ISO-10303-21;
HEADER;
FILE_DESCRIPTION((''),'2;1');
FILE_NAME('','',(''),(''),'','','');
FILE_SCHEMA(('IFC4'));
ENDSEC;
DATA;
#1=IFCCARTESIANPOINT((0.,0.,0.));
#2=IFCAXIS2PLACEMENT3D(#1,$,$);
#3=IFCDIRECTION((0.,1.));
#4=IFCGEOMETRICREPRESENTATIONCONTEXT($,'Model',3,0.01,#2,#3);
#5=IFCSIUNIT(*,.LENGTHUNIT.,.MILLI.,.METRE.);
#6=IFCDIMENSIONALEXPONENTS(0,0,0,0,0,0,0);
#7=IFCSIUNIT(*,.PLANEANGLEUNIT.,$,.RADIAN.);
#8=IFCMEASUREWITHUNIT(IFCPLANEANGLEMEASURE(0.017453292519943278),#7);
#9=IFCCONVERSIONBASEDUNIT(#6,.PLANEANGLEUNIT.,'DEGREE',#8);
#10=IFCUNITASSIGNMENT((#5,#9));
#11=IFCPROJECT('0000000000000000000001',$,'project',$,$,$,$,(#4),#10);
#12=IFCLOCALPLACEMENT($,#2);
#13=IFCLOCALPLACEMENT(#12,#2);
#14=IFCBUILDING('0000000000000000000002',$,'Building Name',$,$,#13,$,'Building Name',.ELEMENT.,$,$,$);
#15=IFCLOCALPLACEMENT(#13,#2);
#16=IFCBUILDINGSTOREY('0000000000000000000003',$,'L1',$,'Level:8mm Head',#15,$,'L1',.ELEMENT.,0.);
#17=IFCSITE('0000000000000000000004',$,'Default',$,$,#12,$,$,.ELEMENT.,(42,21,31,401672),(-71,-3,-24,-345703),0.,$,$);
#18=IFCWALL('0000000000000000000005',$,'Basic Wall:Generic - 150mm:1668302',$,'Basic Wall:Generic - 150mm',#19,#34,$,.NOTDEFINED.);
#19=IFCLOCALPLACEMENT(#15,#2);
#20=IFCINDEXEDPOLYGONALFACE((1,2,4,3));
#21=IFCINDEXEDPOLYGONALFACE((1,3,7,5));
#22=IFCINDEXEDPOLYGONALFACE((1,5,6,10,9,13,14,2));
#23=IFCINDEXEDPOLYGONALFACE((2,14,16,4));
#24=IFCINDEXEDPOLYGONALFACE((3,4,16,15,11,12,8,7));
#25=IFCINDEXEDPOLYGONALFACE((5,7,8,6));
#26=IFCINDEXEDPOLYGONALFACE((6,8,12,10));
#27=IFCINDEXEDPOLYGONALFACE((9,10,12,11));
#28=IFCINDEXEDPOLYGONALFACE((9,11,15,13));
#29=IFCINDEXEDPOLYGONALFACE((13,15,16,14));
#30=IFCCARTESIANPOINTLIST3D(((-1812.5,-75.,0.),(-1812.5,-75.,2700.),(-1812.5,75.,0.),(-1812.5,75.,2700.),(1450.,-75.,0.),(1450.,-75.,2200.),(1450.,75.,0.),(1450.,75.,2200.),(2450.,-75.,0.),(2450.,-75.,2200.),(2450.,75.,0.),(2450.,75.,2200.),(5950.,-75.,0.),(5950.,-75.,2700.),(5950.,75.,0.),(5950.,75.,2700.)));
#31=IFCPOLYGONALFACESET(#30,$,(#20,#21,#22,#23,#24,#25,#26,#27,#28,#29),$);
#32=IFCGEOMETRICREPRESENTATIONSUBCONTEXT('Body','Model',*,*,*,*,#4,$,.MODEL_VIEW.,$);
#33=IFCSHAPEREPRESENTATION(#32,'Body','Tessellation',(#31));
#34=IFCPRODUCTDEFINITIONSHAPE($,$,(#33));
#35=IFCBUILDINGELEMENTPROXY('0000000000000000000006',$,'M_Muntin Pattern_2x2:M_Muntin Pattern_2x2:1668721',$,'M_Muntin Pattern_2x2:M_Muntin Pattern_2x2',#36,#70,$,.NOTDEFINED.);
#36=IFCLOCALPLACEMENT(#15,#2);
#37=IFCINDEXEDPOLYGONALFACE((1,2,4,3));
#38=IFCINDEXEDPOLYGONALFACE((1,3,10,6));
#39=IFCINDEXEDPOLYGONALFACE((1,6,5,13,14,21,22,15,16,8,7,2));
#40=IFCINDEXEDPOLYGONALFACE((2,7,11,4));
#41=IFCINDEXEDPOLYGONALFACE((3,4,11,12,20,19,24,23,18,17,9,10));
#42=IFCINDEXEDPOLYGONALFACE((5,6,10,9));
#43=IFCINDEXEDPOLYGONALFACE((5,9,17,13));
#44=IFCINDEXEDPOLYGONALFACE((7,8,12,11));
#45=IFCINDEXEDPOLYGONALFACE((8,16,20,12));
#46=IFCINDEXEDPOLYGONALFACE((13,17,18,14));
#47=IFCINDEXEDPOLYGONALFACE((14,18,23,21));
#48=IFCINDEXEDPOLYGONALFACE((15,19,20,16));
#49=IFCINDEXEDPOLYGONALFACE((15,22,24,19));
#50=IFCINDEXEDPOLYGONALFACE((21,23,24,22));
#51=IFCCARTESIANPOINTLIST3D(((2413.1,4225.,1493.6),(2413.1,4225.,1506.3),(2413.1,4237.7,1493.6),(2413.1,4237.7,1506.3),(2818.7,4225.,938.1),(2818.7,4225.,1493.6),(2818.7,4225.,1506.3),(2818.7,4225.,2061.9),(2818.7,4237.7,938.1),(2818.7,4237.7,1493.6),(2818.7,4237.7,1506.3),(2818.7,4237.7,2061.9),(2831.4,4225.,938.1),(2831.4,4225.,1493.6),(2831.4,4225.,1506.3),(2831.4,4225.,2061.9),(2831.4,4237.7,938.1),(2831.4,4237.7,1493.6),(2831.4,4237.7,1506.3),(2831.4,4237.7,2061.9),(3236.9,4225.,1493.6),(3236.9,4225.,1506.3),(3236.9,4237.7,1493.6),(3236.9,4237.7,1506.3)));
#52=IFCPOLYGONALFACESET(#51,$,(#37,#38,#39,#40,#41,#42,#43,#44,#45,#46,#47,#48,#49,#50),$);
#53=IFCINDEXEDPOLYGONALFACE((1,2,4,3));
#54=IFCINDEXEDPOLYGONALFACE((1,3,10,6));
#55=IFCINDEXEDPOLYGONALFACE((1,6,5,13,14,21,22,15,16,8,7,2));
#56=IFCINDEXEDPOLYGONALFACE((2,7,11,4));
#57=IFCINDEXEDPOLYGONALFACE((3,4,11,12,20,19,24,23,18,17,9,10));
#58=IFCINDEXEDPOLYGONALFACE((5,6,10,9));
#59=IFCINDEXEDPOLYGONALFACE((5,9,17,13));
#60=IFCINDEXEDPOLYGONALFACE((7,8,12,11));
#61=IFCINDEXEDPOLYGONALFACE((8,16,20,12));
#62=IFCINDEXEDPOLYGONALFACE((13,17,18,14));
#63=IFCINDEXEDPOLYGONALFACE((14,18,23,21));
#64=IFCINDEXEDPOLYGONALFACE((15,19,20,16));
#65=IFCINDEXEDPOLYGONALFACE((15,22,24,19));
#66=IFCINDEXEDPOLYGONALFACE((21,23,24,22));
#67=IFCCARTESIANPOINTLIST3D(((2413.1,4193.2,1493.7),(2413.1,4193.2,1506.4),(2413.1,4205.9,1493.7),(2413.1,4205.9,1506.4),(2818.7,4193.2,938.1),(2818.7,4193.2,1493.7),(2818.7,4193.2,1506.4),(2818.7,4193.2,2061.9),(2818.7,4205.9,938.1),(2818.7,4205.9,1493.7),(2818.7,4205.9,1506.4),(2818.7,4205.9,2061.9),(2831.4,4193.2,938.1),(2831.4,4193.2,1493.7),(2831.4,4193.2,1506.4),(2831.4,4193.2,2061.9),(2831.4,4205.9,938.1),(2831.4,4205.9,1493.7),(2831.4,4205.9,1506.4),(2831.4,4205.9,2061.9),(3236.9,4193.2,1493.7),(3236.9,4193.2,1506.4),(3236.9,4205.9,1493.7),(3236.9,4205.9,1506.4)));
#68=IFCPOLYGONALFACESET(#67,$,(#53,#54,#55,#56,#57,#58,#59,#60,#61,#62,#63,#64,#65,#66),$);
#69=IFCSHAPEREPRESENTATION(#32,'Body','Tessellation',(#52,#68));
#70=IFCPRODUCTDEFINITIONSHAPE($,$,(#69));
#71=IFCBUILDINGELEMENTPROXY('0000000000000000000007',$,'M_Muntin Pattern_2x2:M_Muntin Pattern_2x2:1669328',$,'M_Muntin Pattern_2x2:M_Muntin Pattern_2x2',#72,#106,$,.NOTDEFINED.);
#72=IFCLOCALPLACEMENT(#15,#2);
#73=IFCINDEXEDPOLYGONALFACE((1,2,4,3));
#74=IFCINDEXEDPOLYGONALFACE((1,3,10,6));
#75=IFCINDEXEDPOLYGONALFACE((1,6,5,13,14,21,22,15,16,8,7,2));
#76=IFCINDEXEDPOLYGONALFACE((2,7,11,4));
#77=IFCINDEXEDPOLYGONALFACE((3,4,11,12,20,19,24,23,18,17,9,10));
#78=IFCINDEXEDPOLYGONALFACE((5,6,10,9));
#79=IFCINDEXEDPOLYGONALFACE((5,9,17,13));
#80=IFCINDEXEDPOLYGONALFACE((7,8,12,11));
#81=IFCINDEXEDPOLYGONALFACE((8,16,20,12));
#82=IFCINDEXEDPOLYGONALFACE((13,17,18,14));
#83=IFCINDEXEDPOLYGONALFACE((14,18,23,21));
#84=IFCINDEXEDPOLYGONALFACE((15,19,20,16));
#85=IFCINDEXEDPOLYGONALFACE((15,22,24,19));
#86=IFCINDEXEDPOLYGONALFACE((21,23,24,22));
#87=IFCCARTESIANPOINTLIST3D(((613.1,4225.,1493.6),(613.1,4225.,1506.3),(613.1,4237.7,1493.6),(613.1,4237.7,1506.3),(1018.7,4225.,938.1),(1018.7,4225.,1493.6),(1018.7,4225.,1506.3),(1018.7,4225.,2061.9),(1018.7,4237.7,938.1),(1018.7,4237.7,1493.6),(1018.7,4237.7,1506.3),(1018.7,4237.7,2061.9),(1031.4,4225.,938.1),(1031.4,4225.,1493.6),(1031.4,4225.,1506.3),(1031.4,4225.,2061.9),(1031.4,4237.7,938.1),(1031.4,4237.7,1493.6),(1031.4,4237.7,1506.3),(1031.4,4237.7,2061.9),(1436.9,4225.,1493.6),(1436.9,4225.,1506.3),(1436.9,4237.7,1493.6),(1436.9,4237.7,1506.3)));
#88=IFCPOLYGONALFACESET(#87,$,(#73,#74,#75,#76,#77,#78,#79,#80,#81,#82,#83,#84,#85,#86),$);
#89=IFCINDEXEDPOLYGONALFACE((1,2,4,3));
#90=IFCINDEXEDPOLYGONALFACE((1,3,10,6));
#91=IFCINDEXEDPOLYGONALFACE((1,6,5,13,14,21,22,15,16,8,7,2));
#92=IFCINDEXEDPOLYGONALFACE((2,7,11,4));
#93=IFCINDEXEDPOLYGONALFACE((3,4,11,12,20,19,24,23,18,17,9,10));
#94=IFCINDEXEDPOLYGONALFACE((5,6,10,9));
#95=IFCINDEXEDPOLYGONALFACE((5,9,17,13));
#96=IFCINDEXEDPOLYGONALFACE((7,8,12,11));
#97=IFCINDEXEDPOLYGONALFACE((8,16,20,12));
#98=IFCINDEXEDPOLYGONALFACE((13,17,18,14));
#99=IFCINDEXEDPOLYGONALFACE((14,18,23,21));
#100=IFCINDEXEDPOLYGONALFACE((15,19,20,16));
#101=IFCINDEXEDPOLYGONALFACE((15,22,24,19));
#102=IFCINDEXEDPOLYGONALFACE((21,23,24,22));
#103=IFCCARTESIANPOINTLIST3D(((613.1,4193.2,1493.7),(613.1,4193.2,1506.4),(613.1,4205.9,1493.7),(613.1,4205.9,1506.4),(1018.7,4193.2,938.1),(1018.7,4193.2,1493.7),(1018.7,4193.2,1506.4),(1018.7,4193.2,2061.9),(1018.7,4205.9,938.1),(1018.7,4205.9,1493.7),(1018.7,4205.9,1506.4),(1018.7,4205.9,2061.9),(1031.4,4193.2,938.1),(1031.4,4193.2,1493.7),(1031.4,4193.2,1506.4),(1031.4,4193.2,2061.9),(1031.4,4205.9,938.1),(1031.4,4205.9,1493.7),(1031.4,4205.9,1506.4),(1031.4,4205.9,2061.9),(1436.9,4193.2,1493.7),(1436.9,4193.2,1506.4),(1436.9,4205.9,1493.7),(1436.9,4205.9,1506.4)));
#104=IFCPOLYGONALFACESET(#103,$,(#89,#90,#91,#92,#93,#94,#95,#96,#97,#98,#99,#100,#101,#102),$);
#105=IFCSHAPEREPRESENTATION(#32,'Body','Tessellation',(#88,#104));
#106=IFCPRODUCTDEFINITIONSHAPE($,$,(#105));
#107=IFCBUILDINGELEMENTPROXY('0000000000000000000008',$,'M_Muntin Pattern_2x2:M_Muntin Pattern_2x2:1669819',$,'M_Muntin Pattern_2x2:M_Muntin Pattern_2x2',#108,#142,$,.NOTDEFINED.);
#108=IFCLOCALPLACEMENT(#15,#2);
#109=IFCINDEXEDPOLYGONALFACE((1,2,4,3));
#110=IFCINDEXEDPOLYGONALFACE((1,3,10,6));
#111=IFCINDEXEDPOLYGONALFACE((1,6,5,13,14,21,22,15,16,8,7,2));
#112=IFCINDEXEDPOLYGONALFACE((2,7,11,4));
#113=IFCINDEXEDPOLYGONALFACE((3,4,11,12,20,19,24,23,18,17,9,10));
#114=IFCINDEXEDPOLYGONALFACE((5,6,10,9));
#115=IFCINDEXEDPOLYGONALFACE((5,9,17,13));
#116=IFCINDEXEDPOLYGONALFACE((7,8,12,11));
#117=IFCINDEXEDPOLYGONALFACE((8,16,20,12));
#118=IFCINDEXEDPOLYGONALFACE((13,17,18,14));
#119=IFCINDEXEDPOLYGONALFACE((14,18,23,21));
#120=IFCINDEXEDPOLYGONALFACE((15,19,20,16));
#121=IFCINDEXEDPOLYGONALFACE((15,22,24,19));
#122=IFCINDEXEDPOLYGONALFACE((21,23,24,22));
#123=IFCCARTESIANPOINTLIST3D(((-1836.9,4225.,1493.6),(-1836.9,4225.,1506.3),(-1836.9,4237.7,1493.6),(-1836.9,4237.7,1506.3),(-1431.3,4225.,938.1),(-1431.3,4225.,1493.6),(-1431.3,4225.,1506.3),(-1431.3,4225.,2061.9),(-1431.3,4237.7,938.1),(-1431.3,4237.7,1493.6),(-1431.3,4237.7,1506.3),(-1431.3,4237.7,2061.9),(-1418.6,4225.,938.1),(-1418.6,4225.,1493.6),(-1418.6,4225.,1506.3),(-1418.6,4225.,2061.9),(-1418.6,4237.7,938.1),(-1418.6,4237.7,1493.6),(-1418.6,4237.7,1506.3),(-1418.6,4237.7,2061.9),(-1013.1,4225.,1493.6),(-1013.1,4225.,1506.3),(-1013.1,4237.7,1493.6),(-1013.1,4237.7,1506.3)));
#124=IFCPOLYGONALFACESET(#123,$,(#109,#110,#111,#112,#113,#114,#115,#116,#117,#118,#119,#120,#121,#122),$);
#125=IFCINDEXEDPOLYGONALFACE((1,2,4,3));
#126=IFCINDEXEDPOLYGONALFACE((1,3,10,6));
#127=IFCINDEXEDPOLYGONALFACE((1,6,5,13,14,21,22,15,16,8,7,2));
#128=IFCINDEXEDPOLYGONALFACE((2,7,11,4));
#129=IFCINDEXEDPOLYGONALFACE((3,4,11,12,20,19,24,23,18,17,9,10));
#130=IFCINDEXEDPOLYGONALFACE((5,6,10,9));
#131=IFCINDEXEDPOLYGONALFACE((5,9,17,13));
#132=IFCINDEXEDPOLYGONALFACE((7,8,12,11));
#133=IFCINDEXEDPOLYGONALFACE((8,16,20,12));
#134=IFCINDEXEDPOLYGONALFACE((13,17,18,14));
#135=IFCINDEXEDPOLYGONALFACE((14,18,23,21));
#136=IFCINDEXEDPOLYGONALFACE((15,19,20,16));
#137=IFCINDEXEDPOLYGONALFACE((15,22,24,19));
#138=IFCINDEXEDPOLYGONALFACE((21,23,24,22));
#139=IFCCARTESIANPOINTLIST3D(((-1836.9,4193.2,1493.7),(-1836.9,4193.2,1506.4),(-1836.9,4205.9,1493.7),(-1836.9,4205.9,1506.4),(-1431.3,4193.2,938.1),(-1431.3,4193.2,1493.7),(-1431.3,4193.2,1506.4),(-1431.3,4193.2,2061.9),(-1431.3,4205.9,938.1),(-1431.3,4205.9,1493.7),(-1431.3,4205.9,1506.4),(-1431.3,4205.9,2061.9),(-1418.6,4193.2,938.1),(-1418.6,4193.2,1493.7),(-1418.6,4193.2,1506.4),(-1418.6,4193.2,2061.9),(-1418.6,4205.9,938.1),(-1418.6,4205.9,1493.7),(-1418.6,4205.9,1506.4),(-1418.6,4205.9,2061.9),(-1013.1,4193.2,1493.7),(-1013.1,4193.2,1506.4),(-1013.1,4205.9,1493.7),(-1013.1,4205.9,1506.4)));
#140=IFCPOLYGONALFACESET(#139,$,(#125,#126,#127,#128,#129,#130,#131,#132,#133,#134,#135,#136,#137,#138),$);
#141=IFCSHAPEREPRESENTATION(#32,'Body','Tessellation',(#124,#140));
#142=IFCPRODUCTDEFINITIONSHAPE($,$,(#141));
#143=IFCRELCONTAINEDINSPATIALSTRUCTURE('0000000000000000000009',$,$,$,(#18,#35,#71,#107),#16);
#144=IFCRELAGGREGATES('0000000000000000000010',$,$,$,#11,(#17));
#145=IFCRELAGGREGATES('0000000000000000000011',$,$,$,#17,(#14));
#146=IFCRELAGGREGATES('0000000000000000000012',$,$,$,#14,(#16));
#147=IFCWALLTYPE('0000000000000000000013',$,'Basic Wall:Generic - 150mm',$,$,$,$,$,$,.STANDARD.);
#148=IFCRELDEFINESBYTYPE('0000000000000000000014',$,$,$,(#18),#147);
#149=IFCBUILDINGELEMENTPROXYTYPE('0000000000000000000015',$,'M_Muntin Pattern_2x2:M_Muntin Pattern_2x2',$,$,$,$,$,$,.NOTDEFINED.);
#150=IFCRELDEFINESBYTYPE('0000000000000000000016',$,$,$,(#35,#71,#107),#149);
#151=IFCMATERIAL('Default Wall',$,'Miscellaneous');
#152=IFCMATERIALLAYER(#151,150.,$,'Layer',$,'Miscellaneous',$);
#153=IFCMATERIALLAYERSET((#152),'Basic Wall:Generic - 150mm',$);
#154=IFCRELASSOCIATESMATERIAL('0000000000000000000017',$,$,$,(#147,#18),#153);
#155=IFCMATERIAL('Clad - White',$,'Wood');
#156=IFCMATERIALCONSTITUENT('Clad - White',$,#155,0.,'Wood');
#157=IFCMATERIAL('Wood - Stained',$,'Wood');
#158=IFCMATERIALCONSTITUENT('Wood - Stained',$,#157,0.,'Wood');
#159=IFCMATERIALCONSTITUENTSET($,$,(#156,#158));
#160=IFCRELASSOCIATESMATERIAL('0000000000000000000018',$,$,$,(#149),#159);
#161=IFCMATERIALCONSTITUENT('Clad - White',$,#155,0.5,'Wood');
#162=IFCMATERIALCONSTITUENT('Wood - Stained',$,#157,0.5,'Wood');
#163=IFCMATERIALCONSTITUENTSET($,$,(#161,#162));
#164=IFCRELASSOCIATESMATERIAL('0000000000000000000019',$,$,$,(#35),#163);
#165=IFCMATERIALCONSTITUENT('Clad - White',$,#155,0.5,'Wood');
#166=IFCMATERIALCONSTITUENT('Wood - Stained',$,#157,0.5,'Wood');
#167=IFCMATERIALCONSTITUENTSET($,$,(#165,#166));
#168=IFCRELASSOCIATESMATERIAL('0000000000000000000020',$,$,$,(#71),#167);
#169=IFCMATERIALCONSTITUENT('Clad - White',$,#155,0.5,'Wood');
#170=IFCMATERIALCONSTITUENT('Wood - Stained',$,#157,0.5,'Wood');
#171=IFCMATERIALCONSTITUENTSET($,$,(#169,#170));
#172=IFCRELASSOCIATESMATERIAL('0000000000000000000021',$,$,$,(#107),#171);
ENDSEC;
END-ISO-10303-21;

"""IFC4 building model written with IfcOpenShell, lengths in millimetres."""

from ifc_helpers import new_model, entity, si_unit, converted_unit, direction, frame, frame_2d, origin, place, context, subcontext, project, spatial, polyline, rectangle, outline, extrude, source, transform, mapped, material, layer, layer_set, layer_usage, constituent, constituent_set, type_object, type_shapes, element, save


model = new_model("IFC4")

# Units and contexts
model_context = context("Model", 3, precision=0.01, world=origin(), true_north=direction((0.0, 1.0)))
body_context = subcontext(model_context, "Body", "Model", "MODEL_VIEW")
ifc_project = project(units=[si_unit("LENGTHUNIT", "METRE", prefix="MILLI"), converted_unit("PLANEANGLEUNIT", "DEGREE", entity("IfcPlaneAngleMeasure", 0.017453292519943278), si_unit("PLANEANGLEUNIT", "RADIAN"), dimensions=[0, 0, 0, 0, 0, 0, 0])], contexts=[model_context])

# Site, building, storey
site_placement = place(None, origin())
site = spatial("IfcSite", under=ifc_project, at=site_placement, Name="Default", CompositionType="ELEMENT", RefLatitude=(42, 21, 31, 401672), RefLongitude=(-71, -3, -24, -345703), RefElevation=0.0)
building_placement = place(site_placement, origin())
building = spatial("IfcBuilding", under=site, at=building_placement, Name="Building Name", LongName="Building Name", CompositionType="ELEMENT")
storey_placement = place(building_placement, origin())
storey = spatial("IfcBuildingStorey", under=building, at=storey_placement, Name="L1", ObjectType="Level:8mm Head", LongName="L1", CompositionType="ELEMENT", Elevation=0.0)

# Shared definitions
ifc_material_1 = material(Name="Default Wall", Category="Miscellaneous")
ifc_layer_1 = layer(ifc_material_1, 150.0, Name="Layer", Category="Miscellaneous")
ifc_layer_set_1 = layer_set([ifc_layer_1], Name="Basic Wall:Generic - 150mm")
wall_type = type_object("IfcWallType", Name="Basic Wall:Generic - 150mm", PredefinedType="STANDARD", material=ifc_layer_set_1)

# Wall, openings
ifc_layer_usage_1 = layer_usage(ifc_layer_set_1, "AXIS2", "NEGATIVE", 75.0)
wall_1_placement = place(storey_placement, frame((5950.0, 0.0, 0.0), z_axis=(0.0, 0.0, 1.0), x_axis=(-1.0, 0.0, 0.0)))
wall_1 = element("IfcWall", 1, at=wall_1_placement, inside=storey, type_object=wall_type, material=ifc_layer_usage_1, Name="Basic Wall:Generic - 150mm:1668302", ObjectType="Basic Wall:Generic - 150mm", PredefinedType="NOTDEFINED", context=body_context, shape_type="SweptSolid", body=[
    extrude(rectangle(XDim=7762.5, YDim=150.0, at=frame_2d((3881.2, 0.0), x_axis=(1.0, 0.0))), origin(), (0.0, 0.0, 1.0), 2700.0),
])
opening_1_placement = place(wall_1_placement, frame((3500.0, -75.0, 0.0)))
element("IfcOpeningElement", 2, at=opening_1_placement, cuts=wall_1, PredefinedType="OPENING", context=body_context, shape_type="SweptSolid", body=[
    extrude(rectangle(XDim=2200.0, YDim=1000.0, at=frame_2d((1100.0, 500.0), x_axis=(1.0, 0.0))), frame((0.0, 0.0, 0.0), z_axis=(0.0, 1.0, 0.0), x_axis=(0.0, 0.0, 1.0)), (0.0, 0.0, 1.0), 150.0),
])
opening_2_placement = place(wall_1_placement, frame((5950.0, 0.0, 0.0), z_axis=(0.0, 0.0, 1.0), x_axis=(-1.0, 0.0, 0.0)))
element("IfcOpeningElement", 3, at=opening_2_placement, cuts=wall_1, PredefinedType="OPENING", context=body_context, shape_type="SweptSolid", body=[
    extrude(rectangle(XDim=2200.0, YDim=1000.0, at=frame_2d((0.0, 0.0), x_axis=(1.0, 0.0))), frame((1950.0, 1599.0, 1100.0), z_axis=(0.0, -1.0, 0.0), x_axis=(0.0, 0.0, 1.0)), (0.0, 0.0, 1.0), 3048.0),
])

# Building element proxies
ifc_material_2 = material(Name="Clad - White", Category="Wood")
ifc_constituent_1 = constituent(ifc_material_2, Name="Clad - White", Category="Wood", fraction=0.5)
ifc_material_3 = material(Name="Wood - Stained", Category="Wood")
ifc_constituent_2 = constituent(ifc_material_3, Name="Wood - Stained", Category="Wood", fraction=0.5)
ifc_constituent_set_1 = constituent_set(constituents=[ifc_constituent_1, ifc_constituent_2])
ifc_constituent_3 = constituent(ifc_material_2, Name="Clad - White", Category="Wood", fraction=0.0)
ifc_constituent_4 = constituent(ifc_material_3, Name="Wood - Stained", Category="Wood", fraction=0.0)
ifc_constituent_set_2 = constituent_set(constituents=[ifc_constituent_3, ifc_constituent_4])
building_element_proxy_type_1 = type_object("IfcBuildingElementProxyType", Name="M_Muntin Pattern_2x2:M_Muntin Pattern_2x2", PredefinedType="NOTDEFINED", material=ifc_constituent_set_2)
shared_shape_1 = source(origin(), body_context, "Body", "SweptSolid", [
    extrude(outline(polyline([(6.4, -6.4), (561.9, -6.4), (561.9, 6.3), (6.4, 6.3), (6.4, 411.9), (-6.3, 411.9), (-6.3, 6.3), (-561.9, 6.3), (-561.9, -6.4), (-6.3, -6.4), (-6.3, -411.9), (6.4, -411.9), (6.4, -6.4)])), frame((0.0, -22.2, 561.9), z_axis=(0.0, 1.0, 0.0), x_axis=(0.0, 0.0, 1.0)), (0.0, 0.0, 1.0), 12.7),
    extrude(outline(polyline([(6.4, -6.4), (561.9, -6.4), (561.9, 6.3), (6.4, 6.3), (6.4, 411.9), (-6.3, 411.9), (-6.3, 6.3), (-561.9, 6.3), (-561.9, -6.4), (-6.3, -6.4), (-6.3, -411.9), (6.4, -411.9), (6.4, -6.4)])), frame((0.0, 9.5, 561.9), z_axis=(0.0, 1.0, 0.0), x_axis=(0.0, 0.0, 1.0)), (0.0, 0.0, 1.0), 12.7),
])
type_shapes(building_element_proxy_type_1, [shared_shape_1])
proxy_1_placement = place(storey_placement, frame((2825.0, 4215.5, 938.1), z_axis=(0.0, 0.0, 1.0), x_axis=(-1.0, 0.0, 0.0)))
element("IfcBuildingElementProxy", 4, at=proxy_1_placement, inside=storey, type_object=building_element_proxy_type_1, material=ifc_constituent_set_1, Name="M_Muntin Pattern_2x2:M_Muntin Pattern_2x2:1668721", ObjectType="M_Muntin Pattern_2x2:M_Muntin Pattern_2x2", PredefinedType="NOTDEFINED", context=body_context, shape_type="MappedRepresentation", body=[
    mapped(shared_shape_1, transform((0.0, 0.0, 0.0), scale=1.0)),
])
ifc_constituent_5 = constituent(ifc_material_2, Name="Clad - White", Category="Wood", fraction=0.5)
ifc_constituent_6 = constituent(ifc_material_3, Name="Wood - Stained", Category="Wood", fraction=0.5)
ifc_constituent_set_3 = constituent_set(constituents=[ifc_constituent_5, ifc_constituent_6])
proxy_2_placement = place(storey_placement, frame((1025.0, 4215.5, 938.1), z_axis=(0.0, 0.0, 1.0), x_axis=(-1.0, 0.0, 0.0)))
element("IfcBuildingElementProxy", 5, at=proxy_2_placement, inside=storey, type_object=building_element_proxy_type_1, material=ifc_constituent_set_3, Name="M_Muntin Pattern_2x2:M_Muntin Pattern_2x2:1669328", ObjectType="M_Muntin Pattern_2x2:M_Muntin Pattern_2x2", PredefinedType="NOTDEFINED", context=body_context, shape_type="MappedRepresentation", body=[
    mapped(shared_shape_1, transform((0.0, 0.0, 0.0), scale=1.0)),
])
ifc_constituent_7 = constituent(ifc_material_2, Name="Clad - White", Category="Wood", fraction=0.5)
ifc_constituent_8 = constituent(ifc_material_3, Name="Wood - Stained", Category="Wood", fraction=0.5)
ifc_constituent_set_4 = constituent_set(constituents=[ifc_constituent_7, ifc_constituent_8])
proxy_3_placement = place(storey_placement, frame((-1425.0, 4215.5, 938.1), z_axis=(0.0, 0.0, 1.0), x_axis=(-1.0, 0.0, 0.0)))
element("IfcBuildingElementProxy", 6, at=proxy_3_placement, inside=storey, type_object=building_element_proxy_type_1, material=ifc_constituent_set_4, Name="M_Muntin Pattern_2x2:M_Muntin Pattern_2x2:1669819", ObjectType="M_Muntin Pattern_2x2:M_Muntin Pattern_2x2", PredefinedType="NOTDEFINED", context=body_context, shape_type="MappedRepresentation", body=[
    mapped(shared_shape_1, transform((0.0, 0.0, 0.0), scale=1.0)),
])

save(model, "model.ifc")
